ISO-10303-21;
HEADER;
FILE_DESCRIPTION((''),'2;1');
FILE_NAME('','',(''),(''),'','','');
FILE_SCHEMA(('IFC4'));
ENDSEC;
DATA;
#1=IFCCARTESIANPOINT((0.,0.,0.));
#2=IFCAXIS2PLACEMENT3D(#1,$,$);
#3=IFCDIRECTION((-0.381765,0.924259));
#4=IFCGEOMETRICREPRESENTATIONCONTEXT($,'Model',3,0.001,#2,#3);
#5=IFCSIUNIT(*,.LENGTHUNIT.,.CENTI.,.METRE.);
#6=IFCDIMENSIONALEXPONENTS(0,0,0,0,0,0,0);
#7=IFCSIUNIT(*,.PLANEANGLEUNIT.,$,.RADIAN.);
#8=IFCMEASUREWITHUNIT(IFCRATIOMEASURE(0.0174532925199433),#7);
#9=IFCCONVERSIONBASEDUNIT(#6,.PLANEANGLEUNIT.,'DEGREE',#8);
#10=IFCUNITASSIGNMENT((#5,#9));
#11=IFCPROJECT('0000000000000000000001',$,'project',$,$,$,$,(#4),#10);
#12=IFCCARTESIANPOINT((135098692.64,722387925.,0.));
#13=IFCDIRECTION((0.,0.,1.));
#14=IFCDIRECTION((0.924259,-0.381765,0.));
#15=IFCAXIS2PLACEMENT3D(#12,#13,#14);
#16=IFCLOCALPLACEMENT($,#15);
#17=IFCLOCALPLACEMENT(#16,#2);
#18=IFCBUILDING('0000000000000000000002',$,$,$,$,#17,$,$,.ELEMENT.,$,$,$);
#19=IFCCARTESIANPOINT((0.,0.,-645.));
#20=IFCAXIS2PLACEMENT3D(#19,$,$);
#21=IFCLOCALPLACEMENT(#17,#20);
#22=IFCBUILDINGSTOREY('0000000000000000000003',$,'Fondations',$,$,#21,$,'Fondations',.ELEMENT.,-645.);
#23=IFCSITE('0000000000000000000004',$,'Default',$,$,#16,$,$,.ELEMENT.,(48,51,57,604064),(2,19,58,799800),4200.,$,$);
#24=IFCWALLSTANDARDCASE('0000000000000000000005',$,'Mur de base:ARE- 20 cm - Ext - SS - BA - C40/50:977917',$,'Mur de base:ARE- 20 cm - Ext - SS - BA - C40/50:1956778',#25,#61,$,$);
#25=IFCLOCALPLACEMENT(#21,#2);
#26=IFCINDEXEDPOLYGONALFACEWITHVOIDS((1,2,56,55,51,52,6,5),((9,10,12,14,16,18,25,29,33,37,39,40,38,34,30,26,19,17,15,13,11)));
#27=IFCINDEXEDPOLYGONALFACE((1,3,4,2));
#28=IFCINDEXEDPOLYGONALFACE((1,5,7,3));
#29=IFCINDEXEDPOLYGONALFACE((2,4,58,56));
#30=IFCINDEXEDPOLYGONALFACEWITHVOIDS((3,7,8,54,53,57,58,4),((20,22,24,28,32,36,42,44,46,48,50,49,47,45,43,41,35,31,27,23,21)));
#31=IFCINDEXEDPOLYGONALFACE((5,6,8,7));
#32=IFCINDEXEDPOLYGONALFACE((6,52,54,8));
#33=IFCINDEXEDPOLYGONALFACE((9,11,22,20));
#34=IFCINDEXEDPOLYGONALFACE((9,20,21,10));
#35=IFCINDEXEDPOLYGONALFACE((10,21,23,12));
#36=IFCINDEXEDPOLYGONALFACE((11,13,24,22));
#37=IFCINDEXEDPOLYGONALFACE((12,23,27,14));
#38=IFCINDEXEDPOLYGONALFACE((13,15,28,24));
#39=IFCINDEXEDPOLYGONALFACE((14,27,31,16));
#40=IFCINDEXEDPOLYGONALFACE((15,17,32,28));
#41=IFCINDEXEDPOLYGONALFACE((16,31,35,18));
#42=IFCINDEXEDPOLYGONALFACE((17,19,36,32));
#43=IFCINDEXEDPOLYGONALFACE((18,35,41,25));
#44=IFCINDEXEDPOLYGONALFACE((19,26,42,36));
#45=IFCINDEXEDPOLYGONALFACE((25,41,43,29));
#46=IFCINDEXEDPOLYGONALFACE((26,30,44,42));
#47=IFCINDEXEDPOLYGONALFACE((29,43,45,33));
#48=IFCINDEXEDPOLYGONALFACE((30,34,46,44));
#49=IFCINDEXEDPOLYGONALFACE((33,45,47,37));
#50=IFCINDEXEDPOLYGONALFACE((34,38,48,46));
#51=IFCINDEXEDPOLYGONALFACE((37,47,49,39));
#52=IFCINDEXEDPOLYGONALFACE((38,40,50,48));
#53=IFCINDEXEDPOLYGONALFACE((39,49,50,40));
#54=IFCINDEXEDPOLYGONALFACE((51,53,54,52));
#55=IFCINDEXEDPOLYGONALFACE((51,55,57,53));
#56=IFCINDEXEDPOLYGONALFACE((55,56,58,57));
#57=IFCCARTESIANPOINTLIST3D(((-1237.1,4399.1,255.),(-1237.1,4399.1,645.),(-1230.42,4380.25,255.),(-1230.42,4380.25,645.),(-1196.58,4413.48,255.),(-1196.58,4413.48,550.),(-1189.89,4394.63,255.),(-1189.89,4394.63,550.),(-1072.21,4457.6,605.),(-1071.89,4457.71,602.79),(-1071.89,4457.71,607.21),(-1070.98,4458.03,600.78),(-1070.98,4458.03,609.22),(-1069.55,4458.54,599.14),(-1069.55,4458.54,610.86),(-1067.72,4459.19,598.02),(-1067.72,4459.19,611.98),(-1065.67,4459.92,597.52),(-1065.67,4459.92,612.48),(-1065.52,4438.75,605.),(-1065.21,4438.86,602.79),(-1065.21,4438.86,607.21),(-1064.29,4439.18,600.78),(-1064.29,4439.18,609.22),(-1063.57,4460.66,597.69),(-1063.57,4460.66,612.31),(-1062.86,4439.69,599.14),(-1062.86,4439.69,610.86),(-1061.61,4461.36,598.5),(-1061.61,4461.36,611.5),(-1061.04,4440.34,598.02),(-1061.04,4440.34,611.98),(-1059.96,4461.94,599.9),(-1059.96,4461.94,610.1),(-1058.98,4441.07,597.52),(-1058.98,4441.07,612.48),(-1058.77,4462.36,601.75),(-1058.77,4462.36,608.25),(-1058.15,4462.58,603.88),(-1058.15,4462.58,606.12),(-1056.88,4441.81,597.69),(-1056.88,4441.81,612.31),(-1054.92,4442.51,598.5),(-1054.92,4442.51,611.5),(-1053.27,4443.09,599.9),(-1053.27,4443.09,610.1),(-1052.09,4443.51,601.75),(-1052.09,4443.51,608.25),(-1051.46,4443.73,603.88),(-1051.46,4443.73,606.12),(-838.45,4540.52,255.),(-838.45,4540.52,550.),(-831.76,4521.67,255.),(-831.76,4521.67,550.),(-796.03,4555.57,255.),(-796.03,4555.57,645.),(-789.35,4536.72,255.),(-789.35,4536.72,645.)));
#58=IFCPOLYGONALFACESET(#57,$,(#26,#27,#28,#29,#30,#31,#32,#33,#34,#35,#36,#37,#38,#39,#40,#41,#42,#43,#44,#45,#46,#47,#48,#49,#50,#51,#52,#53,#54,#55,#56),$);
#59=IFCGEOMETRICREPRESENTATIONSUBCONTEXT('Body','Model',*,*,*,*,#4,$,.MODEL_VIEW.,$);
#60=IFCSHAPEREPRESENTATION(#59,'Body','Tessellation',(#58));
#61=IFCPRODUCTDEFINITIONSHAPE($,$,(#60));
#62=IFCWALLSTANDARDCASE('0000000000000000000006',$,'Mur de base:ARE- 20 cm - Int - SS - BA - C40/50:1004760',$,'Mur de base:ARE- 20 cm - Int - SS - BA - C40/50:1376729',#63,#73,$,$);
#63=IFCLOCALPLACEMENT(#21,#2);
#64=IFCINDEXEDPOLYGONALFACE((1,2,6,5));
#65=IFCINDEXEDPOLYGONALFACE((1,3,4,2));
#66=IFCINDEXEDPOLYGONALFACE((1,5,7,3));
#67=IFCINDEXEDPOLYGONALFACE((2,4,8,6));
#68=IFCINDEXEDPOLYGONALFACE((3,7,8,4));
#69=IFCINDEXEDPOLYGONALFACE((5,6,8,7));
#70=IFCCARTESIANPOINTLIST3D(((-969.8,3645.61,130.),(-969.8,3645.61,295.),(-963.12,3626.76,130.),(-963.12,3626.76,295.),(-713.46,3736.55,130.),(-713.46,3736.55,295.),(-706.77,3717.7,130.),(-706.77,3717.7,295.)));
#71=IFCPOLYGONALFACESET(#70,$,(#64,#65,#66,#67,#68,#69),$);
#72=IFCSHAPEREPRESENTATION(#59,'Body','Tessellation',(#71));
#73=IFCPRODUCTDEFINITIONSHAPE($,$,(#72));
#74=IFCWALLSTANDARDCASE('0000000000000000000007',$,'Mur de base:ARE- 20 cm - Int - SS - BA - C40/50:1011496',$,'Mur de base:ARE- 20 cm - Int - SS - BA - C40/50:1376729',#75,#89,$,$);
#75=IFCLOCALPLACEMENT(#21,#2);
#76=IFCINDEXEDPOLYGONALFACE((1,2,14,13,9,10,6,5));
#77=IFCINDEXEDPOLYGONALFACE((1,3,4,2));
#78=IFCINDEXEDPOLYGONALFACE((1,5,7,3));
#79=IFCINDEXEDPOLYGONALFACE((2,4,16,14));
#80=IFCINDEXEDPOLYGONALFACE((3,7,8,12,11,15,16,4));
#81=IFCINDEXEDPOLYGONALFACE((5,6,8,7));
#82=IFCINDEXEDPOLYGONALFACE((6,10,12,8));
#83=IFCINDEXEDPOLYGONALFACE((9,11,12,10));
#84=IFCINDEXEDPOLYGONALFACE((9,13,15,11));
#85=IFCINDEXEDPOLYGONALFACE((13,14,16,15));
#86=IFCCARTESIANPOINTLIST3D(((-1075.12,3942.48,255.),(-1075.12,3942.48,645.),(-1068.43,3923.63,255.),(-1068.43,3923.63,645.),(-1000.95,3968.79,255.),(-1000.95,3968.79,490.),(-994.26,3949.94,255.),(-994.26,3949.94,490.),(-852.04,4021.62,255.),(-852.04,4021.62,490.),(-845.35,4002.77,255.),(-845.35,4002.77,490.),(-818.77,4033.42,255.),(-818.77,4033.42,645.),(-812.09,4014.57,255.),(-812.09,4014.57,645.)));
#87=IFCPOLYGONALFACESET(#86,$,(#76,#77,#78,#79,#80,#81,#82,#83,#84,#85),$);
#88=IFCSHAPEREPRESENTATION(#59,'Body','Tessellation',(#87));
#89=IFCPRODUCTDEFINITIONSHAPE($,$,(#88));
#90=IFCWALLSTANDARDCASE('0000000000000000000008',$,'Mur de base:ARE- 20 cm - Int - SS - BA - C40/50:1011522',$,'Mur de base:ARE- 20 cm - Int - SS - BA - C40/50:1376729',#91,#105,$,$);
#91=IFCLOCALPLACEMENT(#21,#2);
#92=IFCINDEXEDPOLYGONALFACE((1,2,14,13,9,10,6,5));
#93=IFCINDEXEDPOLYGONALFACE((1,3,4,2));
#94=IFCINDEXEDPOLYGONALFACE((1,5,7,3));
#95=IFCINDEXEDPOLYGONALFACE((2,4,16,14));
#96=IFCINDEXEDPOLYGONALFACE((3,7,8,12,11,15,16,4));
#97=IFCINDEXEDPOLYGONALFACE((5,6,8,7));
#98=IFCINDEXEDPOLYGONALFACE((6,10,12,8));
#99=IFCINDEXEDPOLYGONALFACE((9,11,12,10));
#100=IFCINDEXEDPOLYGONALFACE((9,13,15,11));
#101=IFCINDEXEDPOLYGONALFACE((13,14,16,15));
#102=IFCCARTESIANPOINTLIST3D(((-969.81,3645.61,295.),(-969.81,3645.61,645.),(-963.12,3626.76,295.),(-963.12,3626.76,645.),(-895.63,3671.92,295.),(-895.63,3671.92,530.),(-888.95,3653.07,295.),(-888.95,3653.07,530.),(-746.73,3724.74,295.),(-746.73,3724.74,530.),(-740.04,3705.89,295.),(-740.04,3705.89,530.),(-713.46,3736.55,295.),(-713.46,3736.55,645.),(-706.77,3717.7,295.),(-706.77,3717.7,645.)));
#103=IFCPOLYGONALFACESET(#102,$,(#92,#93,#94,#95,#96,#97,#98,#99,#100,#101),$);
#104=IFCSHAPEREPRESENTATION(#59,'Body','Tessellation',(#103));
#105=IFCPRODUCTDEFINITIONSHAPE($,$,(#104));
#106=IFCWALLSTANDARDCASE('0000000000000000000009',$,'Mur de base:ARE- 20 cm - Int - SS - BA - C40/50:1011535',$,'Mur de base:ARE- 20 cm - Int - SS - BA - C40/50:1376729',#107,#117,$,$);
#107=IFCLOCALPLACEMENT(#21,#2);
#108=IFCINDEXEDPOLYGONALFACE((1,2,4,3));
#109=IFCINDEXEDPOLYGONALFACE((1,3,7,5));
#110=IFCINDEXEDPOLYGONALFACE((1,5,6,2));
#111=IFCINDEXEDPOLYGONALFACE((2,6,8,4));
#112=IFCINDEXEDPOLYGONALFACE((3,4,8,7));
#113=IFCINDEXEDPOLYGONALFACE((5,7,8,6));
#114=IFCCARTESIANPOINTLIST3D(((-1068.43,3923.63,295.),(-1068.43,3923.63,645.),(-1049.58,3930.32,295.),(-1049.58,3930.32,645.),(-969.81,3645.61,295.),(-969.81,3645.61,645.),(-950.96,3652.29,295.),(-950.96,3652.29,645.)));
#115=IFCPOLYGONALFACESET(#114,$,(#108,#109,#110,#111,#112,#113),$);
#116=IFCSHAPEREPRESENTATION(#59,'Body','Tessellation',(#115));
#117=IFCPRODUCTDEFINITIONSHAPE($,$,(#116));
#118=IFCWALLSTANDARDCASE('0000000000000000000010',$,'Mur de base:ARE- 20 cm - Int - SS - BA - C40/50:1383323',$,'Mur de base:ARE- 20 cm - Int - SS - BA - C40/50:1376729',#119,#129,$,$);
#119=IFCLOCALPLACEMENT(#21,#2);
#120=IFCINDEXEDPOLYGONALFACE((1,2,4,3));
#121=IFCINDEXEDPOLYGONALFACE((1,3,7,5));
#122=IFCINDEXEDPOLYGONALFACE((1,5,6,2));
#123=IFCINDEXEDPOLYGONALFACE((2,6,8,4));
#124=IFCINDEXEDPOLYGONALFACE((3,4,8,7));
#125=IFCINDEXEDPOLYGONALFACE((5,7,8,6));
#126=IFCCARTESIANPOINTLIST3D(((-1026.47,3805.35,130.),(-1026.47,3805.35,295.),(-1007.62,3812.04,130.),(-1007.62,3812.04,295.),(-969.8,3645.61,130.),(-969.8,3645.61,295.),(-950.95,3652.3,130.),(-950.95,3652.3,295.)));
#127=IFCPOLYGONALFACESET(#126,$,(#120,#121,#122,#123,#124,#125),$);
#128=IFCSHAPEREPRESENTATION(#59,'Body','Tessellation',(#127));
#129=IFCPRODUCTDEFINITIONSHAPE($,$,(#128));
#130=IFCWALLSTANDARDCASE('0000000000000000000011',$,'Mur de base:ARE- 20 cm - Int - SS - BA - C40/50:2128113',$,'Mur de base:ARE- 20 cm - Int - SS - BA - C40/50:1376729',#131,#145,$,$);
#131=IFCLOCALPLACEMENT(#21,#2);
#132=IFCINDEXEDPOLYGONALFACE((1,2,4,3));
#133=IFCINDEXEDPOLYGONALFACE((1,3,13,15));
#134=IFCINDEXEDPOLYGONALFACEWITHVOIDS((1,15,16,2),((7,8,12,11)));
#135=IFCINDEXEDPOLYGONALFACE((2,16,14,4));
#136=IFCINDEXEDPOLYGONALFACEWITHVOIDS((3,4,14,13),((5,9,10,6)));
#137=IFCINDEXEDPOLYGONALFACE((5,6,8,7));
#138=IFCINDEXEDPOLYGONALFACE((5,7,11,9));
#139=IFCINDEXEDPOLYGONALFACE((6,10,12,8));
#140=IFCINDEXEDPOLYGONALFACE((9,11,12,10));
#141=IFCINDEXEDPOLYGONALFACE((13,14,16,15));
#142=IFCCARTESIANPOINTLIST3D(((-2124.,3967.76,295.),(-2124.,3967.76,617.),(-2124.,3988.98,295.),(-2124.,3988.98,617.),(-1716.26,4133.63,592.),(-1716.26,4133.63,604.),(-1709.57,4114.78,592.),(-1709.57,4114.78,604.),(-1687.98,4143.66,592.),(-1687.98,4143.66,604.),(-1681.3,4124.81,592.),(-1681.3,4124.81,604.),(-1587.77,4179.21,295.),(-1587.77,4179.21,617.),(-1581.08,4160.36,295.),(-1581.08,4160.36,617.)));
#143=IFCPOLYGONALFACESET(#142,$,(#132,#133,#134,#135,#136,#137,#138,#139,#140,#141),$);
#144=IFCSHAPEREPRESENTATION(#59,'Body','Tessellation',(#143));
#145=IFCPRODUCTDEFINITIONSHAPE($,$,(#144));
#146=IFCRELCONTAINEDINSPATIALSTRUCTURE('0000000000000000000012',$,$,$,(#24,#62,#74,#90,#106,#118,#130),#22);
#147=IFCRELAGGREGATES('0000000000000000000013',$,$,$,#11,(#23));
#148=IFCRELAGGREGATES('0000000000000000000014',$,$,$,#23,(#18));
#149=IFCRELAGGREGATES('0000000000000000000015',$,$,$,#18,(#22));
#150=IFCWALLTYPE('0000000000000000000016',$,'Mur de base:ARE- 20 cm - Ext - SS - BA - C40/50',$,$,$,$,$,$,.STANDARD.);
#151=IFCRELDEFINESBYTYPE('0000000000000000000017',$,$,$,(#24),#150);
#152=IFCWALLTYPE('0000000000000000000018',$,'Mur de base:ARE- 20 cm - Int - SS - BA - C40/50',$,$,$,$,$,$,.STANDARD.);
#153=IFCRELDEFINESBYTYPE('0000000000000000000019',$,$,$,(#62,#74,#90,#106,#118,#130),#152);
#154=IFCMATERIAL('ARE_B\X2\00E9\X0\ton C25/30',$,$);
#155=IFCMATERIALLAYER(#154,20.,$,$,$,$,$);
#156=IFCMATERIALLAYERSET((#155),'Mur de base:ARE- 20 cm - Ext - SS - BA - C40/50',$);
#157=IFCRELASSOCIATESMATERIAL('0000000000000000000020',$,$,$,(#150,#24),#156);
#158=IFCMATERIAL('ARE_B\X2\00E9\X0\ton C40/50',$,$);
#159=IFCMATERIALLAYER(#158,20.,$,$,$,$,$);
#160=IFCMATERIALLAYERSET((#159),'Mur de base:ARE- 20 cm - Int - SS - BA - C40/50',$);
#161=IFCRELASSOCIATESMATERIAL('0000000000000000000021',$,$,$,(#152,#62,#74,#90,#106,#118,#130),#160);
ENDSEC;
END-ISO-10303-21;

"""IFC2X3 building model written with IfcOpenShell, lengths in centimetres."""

from ifc_helpers import new_model, entity, si_unit, converted_unit, direction, frame, frame_2d, origin, place, context, subcontext, project, spatial, polyline, rectangle, circle, outline, extrude, clip, bounded_halfspace, material, layer, layer_set, layer_usage, type_object, element, save


model = new_model("IFC2X3")

# Units and contexts
model_context = context("Model", 3, precision=0.001, world=origin(), true_north=direction((-0.381765, 0.924259)))
body_context = subcontext(model_context, "Body", "Model", "MODEL_VIEW")
ifc_project = project(units=[si_unit("LENGTHUNIT", "METRE", prefix="CENTI"), converted_unit("PLANEANGLEUNIT", "DEGREE", entity("IfcRatioMeasure", 0.0174532925199433), si_unit("PLANEANGLEUNIT", "RADIAN"), dimensions=[0, 0, 0, 0, 0, 0, 0])], contexts=[model_context])

# Site, building, storey
site_placement = place(None, frame((135098692.64, 722387925.0, 0.0), z_axis=(0.0, 0.0, 1.0), x_axis=(0.924259, -0.381765, 0.0)))
site = spatial("IfcSite", under=ifc_project, at=site_placement, Name="Default", CompositionType="ELEMENT", RefLatitude=(48, 51, 57, 604064), RefLongitude=(2, 19, 58, 799800), RefElevation=4200.0)
building_placement = place(site_placement, origin())
building = spatial("IfcBuilding", under=site, at=building_placement, CompositionType="ELEMENT")
storey_placement = place(building_placement, frame((0.0, 0.0, -645.0)))
storey = spatial("IfcBuildingStorey", under=building, at=storey_placement, Name="Fondations", LongName="Fondations", CompositionType="ELEMENT", Elevation=-645.0)

# Shared definitions
ifc_material_1 = material(Name="ARE_Béton C40/50")
ifc_material_2 = material(Name="ARE_Béton C25/30")

# Shared definitions
ifc_layer_1 = layer(ifc_material_2, 20.0)
ifc_layer_set_1 = layer_set([ifc_layer_1], Name="Mur de base:ARE- 20 cm - Ext - SS - BA - C40/50")
wall_type_1 = type_object("IfcWallType", Name="Mur de base:ARE- 20 cm - Ext - SS - BA - C40/50", PredefinedType="STANDARD", material=ifc_layer_set_1)

# Wall, openings
ifc_layer_usage_1 = layer_usage(ifc_layer_set_1, "AXIS2", "NEGATIVE", 10.0)
wall_1_placement = place(storey_placement, frame((-1233.76, 4389.68, 255.0), z_axis=(0.0, 0.0, 1.0), x_axis=(0.942456, 0.334331, 0.0)))
wall_1 = element("IfcWallStandardCase", 1, at=wall_1_placement, inside=storey, type_object=wall_type_1, material=ifc_layer_usage_1, Name="Mur de base:ARE- 20 cm - Ext - SS - BA - C40/50:977917", ObjectType="Mur de base:ARE- 20 cm - Ext - SS - BA - C40/50:1956778", context=body_context, shape_type="SweptSolid", body=[
    extrude(rectangle(XDim=468.0, YDim=20.0, at=frame_2d((234.0, 0.0), x_axis=(-1.0, 0.0))), origin(), (0.0, 0.0, 1.0), 390.0),
])
opening_1_placement = place(wall_1_placement, origin())
element("IfcOpeningElement", 2, at=opening_1_placement, cuts=wall_1, ObjectType="Opening", context=body_context, shape_type="SweptSolid", body=[
    extrude(circle(Radius=7.5, at=frame_2d((0.0, 0.0), x_axis=(1.0, 0.0))), frame((182.46, -10.0, 350.0), z_axis=(0.0, 1.0, 0.0), x_axis=(-1.0, 0.0, 0.0)), (0.0, 0.0, 1.0), 20.0),
])
opening_2_placement = place(wall_1_placement, frame((-304.84, -4549.56, -255.0), z_axis=(0.0, 0.0, 1.0), x_axis=(0.942456, -0.334331, 0.0)))
element("IfcOpeningElement", 3, at=opening_2_placement, cuts=wall_1, ObjectType="Opening", context=body_context, shape_type="SweptSolid", body=[
    extrude(rectangle(XDim=295.0, YDim=380.0, at=frame_2d((0.0, 0.0), x_axis=(1.0, 0.0))), frame((-966.56, 4333.37, 402.5), z_axis=(-0.334331, 0.942456, 0.0), x_axis=(0.0, 0.0, -1.0)), (0.0, 0.0, 1.0), 304.8),
])

# Walls, openings
ifc_layer_2 = layer(ifc_material_1, 20.0)
ifc_layer_set_2 = layer_set([ifc_layer_2], Name="Mur de base:ARE- 20 cm - Int - SS - BA - C40/50")
ifc_layer_usage_2 = layer_usage(ifc_layer_set_2, "AXIS2", "NEGATIVE", 10.0)
wall_type_2 = type_object("IfcWallType", Name="Mur de base:ARE- 20 cm - Int - SS - BA - C40/50", PredefinedType="STANDARD", material=ifc_layer_set_2)
wall_2_placement = place(storey_placement, frame((-966.46, 3636.18, 130.0), z_axis=(0.0, 0.0, 1.0), x_axis=(0.942456, 0.334331, 0.0)))
wall_2 = element("IfcWallStandardCase", 4, at=wall_2_placement, inside=storey, type_object=wall_type_2, material=ifc_layer_usage_2, Name="Mur de base:ARE- 20 cm - Int - SS - BA - C40/50:1004760", ObjectType="Mur de base:ARE- 20 cm - Int - SS - BA - C40/50:1376729", context=body_context, shape_type="SweptSolid", body=[
    extrude(rectangle(XDim=272.0, YDim=20.0, at=frame_2d((136.0, 0.0), x_axis=(-1.0, 0.0))), origin(), (0.0, 0.0, 1.0), 165.0),
])
opening_3_placement = place(wall_2_placement, origin())
element("IfcOpeningElement", 5, at=opening_3_placement, cuts=wall_2, ObjectType="Opening", context=body_context, shape_type="SweptSolid", body=[
    extrude(rectangle(XDim=25.0, YDim=25.5, at=frame_2d((0.0, 0.0), x_axis=(1.0, 0.0))), frame((435.27, -10.0, 67.5), z_axis=(0.0, 1.0, 0.0), x_axis=(0.0, 0.0, -1.0)), (0.0, 0.0, 1.0), 20.0),
])
ifc_layer_usage_3 = layer_usage(ifc_layer_set_2, "AXIS2", "NEGATIVE", 10.0)
wall_3_placement = place(storey_placement, frame((-1071.78, 3933.06, 255.0), z_axis=(0.0, 0.0, 1.0), x_axis=(0.942456, 0.334331, 0.0)))
wall_3 = element("IfcWallStandardCase", 6, at=wall_3_placement, inside=storey, type_object=wall_type_2, material=ifc_layer_usage_3, Name="Mur de base:ARE- 20 cm - Int - SS - BA - C40/50:1011496", ObjectType="Mur de base:ARE- 20 cm - Int - SS - BA - C40/50:1376729", context=body_context, shape_type="SweptSolid", body=[
    extrude(rectangle(XDim=272.0, YDim=20.0, at=frame_2d((136.0, 0.0), x_axis=(-1.0, 0.0))), origin(), (0.0, 0.0, 1.0), 390.0),
])
opening_4_placement = place(wall_3_placement, frame((-304.84, -4065.06, -255.0), z_axis=(0.0, 0.0, 1.0), x_axis=(0.942456, -0.334331, 0.0)))
element("IfcOpeningElement", 7, at=opening_4_placement, cuts=wall_3, ObjectType="Opening", context=body_context, shape_type="SweptSolid", body=[
    extrude(rectangle(XDim=235.0, YDim=158.0, at=frame_2d((0.0, 0.0), x_axis=(0.0, 1.0))), frame((-868.86, 3832.73, 372.5), z_axis=(-0.334331, 0.942456, 0.0), x_axis=(0.942456, 0.334331, 0.0)), (0.0, 0.0, 1.0), 304.8),
])
ifc_layer_usage_4 = layer_usage(ifc_layer_set_2, "AXIS2", "NEGATIVE", 10.0)
wall_4_placement = place(storey_placement, frame((-966.46, 3636.18, 295.0), z_axis=(0.0, 0.0, 1.0), x_axis=(0.942456, 0.334331, 0.0)))
wall_4 = element("IfcWallStandardCase", 8, at=wall_4_placement, inside=storey, type_object=wall_type_2, material=ifc_layer_usage_4, Name="Mur de base:ARE- 20 cm - Int - SS - BA - C40/50:1011522", ObjectType="Mur de base:ARE- 20 cm - Int - SS - BA - C40/50:1376729", context=body_context, shape_type="SweptSolid", body=[
    extrude(rectangle(XDim=272.0, YDim=20.0, at=frame_2d((136.0, 0.0), x_axis=(-1.0, 0.0))), origin(), (0.0, 0.0, 1.0), 350.0),
])
opening_5_placement = place(wall_4_placement, frame((-304.84, -3750.06, -295.0), z_axis=(0.0, 0.0, 1.0), x_axis=(0.942456, -0.334331, 0.0)))
element("IfcOpeningElement", 9, at=opening_5_placement, cuts=wall_4, ObjectType="Opening", context=body_context, shape_type="SweptSolid", body=[
    extrude(rectangle(XDim=235.0, YDim=158.0, at=frame_2d((0.0, 0.0), x_axis=(1.0, 0.0))), frame((-770.23, 3554.7, 412.5), z_axis=(-0.334331, 0.942456, 0.0), x_axis=(0.0, 0.0, -1.0)), (0.0, 0.0, 1.0), 304.8),
])

# Walls
ifc_layer_usage_5 = layer_usage(ifc_layer_set_2, "AXIS2", "NEGATIVE", 10.0)
wall_5_placement = place(storey_placement, frame((-1059.01, 3926.98, 295.0), z_axis=(0.0, 0.0, 1.0), x_axis=(0.334331, -0.942456, 0.0)))
element("IfcWallStandardCase", 10, at=wall_5_placement, inside=storey, type_object=wall_type_2, material=ifc_layer_usage_5, Name="Mur de base:ARE- 20 cm - Int - SS - BA - C40/50:1011535", ObjectType="Mur de base:ARE- 20 cm - Int - SS - BA - C40/50:1376729", context=body_context, shape_type="SweptSolid", body=[
    extrude(rectangle(XDim=295.0, YDim=20.0, at=frame_2d((147.5, 0.0), x_axis=(-1.0, 0.0))), origin(), (0.0, 0.0, 1.0), 350.0),
])
ifc_layer_usage_6 = layer_usage(ifc_layer_set_2, "AXIS2", "NEGATIVE", 10.0)
wall_6_placement = place(storey_placement, frame((-1017.05, 3808.7, 130.0), z_axis=(0.0, 0.0, 1.0), x_axis=(0.334333, -0.942455, 0.0)))
element("IfcWallStandardCase", 11, at=wall_6_placement, inside=storey, type_object=wall_type_2, material=ifc_layer_usage_6, Name="Mur de base:ARE- 20 cm - Int - SS - BA - C40/50:1383323", ObjectType="Mur de base:ARE- 20 cm - Int - SS - BA - C40/50:1376729", context=body_context, shape_type="SweptSolid", body=[
    extrude(rectangle(XDim=169.5, YDim=20.0, at=frame_2d((84.75, 0.0), x_axis=(-1.0, 0.0))), origin(), (0.0, 0.0, 1.0), 165.0),
])

# Wall, opening
ifc_layer_usage_7 = layer_usage(ifc_layer_set_2, "AXIS2", "NEGATIVE", 10.0)
wall_7_placement = place(storey_placement, frame((-1584.42, 4169.79, 295.0), z_axis=(0.0, 0.0, 1.0), x_axis=(-0.942455, -0.334333, 0.0)))
wall_7 = element("IfcWallStandardCase", 12, at=wall_7_placement, inside=storey, type_object=wall_type_2, material=ifc_layer_usage_7, Name="Mur de base:ARE- 20 cm - Int - SS - BA - C40/50:2128113", ObjectType="Mur de base:ARE- 20 cm - Int - SS - BA - C40/50:1376729", context=body_context, shape_type="Clipping", body=[
    clip(extrude(outline(polyline([(568.98, -10.0), (576.07, 10.0), (0.0, 10.0), (0.0, -10.0), (568.98, -10.0)])), origin(), (0.0, 0.0, 1.0), 322.0), bounded_halfspace(frame((0.0, -10.0, 322.0), z_axis=(0.0, 0.0, -1.0), x_axis=(-0.972333, -0.233599, 0.0)), True, frame((0.0, -10.0, 322.0)), polyline([(0.0, 0.0), (568.97, 0.0), (576.07, 20.0), (0.0, 20.0), (0.0, 0.0)]))),
])
opening_6_placement = place(wall_7_placement, origin())
element("IfcOpeningElement", 13, at=opening_6_placement, cuts=wall_7, ObjectType="Opening", context=body_context, shape_type="SweptSolid", body=[
    extrude(rectangle(XDim=12.0, YDim=30.0, at=frame_2d((0.0, 0.0), x_axis=(0.0, 1.0))), frame((121.33, -10.0, 303.0), z_axis=(0.0, 1.0, 0.0), x_axis=(1.0, 0.0, 0.0)), (0.0, 0.0, 1.0), 20.0),
])

save(model, "model.ifc")
